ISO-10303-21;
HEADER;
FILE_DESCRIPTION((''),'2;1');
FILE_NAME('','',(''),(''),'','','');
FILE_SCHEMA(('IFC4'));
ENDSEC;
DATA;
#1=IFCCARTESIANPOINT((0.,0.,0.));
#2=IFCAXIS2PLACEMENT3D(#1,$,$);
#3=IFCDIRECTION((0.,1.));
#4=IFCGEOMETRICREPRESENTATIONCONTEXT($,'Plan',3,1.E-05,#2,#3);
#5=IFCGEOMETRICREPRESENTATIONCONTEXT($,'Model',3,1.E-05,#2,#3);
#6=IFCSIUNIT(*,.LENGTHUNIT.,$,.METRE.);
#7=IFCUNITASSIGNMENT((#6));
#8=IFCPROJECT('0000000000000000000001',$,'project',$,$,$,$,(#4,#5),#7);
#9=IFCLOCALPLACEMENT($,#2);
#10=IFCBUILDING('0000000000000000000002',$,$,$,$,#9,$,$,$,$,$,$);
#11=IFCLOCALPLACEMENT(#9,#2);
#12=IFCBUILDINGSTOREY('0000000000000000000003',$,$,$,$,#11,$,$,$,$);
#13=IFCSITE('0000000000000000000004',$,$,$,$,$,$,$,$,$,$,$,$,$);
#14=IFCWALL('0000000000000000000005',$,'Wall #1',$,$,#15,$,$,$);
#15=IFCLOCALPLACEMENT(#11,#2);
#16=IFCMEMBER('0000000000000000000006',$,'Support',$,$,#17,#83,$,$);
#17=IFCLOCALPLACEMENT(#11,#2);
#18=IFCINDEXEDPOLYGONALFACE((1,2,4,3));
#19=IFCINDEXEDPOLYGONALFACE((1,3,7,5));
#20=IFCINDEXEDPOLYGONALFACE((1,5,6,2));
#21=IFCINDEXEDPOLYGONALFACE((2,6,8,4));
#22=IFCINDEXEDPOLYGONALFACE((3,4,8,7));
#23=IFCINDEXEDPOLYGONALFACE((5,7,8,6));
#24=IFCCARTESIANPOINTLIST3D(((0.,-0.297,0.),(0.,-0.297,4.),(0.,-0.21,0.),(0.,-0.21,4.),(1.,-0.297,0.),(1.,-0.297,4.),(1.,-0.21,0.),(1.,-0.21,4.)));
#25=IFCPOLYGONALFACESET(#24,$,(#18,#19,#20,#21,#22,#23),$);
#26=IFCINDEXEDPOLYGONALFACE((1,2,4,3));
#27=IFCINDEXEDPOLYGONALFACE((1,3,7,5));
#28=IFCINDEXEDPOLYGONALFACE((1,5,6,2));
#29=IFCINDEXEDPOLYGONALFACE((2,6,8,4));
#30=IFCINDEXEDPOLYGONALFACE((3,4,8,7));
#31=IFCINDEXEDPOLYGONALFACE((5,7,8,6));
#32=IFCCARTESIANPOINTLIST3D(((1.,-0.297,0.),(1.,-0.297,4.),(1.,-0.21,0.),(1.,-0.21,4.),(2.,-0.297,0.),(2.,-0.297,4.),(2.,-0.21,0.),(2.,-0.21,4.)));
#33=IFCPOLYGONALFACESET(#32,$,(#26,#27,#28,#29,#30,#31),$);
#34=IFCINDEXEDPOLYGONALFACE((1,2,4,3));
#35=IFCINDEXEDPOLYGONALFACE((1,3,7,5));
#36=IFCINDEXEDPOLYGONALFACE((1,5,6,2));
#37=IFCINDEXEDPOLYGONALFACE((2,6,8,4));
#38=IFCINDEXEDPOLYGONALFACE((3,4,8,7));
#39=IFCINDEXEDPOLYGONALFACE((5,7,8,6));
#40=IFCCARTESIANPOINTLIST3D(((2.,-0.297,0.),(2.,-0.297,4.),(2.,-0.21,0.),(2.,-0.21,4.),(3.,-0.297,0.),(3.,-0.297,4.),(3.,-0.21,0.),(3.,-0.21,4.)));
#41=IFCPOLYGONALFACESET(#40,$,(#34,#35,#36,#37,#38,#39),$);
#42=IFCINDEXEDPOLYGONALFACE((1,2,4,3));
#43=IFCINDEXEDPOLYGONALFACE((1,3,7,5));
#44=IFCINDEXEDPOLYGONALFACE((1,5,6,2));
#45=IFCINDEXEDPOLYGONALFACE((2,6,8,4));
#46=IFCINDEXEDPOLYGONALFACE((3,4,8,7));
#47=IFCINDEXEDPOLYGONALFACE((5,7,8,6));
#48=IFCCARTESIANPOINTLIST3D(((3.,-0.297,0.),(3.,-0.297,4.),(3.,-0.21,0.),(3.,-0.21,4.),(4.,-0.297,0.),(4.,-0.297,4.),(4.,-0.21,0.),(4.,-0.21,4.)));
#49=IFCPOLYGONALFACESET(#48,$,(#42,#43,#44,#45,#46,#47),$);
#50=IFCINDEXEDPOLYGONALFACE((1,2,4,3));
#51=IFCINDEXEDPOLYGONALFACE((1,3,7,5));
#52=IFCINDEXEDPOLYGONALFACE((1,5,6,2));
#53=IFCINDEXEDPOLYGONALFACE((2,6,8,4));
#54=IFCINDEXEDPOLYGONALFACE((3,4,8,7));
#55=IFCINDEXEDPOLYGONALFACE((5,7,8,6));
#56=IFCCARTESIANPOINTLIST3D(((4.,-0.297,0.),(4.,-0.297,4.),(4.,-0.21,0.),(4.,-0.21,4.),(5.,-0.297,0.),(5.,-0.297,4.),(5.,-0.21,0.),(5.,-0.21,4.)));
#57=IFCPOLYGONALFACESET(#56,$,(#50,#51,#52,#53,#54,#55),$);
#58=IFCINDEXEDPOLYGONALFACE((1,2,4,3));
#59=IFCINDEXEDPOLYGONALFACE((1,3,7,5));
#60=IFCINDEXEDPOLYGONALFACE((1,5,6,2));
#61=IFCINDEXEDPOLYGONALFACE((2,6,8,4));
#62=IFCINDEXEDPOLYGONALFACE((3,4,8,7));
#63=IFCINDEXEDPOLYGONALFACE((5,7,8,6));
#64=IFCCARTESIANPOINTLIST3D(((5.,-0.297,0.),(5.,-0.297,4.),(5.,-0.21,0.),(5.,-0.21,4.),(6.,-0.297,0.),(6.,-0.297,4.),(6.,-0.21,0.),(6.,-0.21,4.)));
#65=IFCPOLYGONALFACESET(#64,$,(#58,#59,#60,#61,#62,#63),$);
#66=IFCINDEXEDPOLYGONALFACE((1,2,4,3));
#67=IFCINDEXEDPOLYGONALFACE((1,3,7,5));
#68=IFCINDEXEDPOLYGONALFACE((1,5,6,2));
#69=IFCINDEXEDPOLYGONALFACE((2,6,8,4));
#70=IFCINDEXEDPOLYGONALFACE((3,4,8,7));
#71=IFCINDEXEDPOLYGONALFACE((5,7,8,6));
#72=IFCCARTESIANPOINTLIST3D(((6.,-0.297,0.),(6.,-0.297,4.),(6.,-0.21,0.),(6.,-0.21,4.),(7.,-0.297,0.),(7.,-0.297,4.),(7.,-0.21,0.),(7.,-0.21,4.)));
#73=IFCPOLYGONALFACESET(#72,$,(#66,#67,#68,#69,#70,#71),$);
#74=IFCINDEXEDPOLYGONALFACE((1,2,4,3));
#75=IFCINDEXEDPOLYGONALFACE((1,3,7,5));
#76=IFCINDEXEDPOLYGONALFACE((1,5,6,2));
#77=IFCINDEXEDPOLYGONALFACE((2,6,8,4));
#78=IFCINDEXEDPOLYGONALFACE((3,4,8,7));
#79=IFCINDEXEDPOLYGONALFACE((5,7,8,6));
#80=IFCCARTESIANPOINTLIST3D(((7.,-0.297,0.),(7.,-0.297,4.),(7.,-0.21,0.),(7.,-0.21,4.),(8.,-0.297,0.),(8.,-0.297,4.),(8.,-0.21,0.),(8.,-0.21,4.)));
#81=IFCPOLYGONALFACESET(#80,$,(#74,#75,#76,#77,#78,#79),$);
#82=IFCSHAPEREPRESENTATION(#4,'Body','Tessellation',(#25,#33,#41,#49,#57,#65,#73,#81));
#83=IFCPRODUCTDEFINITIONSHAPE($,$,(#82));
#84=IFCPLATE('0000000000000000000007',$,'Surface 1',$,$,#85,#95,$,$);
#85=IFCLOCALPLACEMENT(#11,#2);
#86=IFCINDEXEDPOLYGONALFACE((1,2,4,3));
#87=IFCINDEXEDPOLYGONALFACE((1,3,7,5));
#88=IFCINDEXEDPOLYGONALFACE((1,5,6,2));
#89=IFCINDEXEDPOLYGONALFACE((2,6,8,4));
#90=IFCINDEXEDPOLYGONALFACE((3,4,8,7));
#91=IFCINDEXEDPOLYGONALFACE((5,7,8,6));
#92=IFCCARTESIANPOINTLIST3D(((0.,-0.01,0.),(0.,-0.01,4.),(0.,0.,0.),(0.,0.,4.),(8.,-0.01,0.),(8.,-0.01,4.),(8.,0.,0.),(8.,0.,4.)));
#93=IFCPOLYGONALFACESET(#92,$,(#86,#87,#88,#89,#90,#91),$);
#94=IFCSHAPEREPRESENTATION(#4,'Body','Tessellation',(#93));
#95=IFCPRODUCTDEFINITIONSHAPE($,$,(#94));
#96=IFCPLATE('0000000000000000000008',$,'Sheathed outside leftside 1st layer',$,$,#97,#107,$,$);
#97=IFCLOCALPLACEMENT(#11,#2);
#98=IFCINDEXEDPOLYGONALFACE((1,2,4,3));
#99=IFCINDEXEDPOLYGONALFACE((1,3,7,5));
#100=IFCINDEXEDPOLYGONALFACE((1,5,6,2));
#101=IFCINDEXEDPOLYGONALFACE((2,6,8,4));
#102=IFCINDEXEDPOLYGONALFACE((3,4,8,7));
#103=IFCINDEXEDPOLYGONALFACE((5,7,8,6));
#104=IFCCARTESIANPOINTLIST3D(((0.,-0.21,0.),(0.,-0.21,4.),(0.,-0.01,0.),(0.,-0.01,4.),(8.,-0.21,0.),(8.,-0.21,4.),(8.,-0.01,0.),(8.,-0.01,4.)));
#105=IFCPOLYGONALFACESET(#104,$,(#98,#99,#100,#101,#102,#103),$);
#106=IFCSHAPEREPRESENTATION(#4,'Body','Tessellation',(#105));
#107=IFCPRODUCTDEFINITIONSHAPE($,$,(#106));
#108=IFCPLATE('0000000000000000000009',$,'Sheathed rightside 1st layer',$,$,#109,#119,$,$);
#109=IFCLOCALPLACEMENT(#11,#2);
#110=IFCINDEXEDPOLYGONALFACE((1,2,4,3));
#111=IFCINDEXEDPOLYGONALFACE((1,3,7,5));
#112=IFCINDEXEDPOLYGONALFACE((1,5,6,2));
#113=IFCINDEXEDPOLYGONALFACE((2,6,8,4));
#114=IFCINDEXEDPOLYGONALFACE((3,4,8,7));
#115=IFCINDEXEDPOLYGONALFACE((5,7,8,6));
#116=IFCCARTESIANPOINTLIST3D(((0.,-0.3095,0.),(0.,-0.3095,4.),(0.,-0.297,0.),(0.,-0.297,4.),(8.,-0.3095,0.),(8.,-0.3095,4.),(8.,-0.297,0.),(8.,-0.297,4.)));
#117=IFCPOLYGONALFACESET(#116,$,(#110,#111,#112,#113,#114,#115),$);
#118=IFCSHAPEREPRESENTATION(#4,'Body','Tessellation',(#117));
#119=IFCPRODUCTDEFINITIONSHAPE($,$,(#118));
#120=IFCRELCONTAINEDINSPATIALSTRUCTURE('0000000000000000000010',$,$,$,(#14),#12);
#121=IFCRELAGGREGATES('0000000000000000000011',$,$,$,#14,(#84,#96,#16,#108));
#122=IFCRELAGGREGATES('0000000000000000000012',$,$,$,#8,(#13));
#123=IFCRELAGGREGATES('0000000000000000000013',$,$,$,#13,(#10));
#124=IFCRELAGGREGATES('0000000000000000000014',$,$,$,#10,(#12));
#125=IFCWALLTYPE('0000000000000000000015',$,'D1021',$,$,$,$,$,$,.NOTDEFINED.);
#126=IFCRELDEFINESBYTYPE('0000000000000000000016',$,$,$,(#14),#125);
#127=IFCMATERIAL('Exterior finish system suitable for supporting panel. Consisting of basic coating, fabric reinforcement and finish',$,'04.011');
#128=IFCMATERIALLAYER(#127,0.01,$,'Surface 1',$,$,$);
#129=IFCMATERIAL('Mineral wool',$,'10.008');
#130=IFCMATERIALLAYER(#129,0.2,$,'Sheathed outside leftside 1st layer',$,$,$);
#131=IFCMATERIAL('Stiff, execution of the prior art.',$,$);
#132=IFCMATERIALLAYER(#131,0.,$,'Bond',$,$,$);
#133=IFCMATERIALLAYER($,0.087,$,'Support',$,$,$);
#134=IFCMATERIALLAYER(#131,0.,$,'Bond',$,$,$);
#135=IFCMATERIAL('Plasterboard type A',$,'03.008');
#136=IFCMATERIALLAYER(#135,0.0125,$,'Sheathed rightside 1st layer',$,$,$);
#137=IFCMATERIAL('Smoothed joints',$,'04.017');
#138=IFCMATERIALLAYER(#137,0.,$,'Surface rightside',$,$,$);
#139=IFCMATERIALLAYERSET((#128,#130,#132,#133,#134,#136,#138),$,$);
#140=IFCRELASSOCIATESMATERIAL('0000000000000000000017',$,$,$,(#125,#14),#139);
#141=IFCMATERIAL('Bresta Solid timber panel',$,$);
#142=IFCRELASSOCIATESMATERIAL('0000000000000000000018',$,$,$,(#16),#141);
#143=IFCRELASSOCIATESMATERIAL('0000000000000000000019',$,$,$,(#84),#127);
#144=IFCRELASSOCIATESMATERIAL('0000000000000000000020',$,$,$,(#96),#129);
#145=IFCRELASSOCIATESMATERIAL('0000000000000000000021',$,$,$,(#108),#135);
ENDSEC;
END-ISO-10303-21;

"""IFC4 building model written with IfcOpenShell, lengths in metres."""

from ifc_helpers import new_model, si_unit, direction, frame, frame_2d, origin, origin_with_axes, place, context, project, spatial, rectangle, extrude, material, layer, layer_set, type_object, element, aggregate, save


model = new_model("IFC4")

# Units and contexts
plan_context = context("Plan", 3, precision=1e-05, world=origin(), true_north=direction((0.0, 1.0)))
model_context = context("Model", 3, precision=1e-05, world=origin(), true_north=direction((0.0, 1.0)))
ifc_project = project(units=[si_unit("LENGTHUNIT", "METRE")], contexts=[plan_context, model_context])

# Site, building, storey
site = spatial("IfcSite", under=ifc_project)
building_placement = place(None, origin())
building = spatial("IfcBuilding", under=site, at=building_placement)
storey_placement = place(building_placement, origin())
storey = spatial("IfcBuildingStorey", under=building, at=storey_placement)

# Wall, member, plates
ifc_material_1 = material(Name="Exterior finish system suitable for supporting panel. Consisting of basic coating, fabric reinforcement and finish", Category="04.011")
ifc_layer_1 = layer(ifc_material_1, 0.01, Name="Surface 1")
ifc_material_2 = material(Name="Mineral wool", Category="10.008")
ifc_layer_2 = layer(ifc_material_2, 0.2, Name="Sheathed outside leftside 1st layer")
ifc_material_3 = material(Name="Stiff, execution of the prior art.")
ifc_layer_3 = layer(ifc_material_3, 0.0, Name="Bond")
ifc_layer_4 = layer(None, 0.087, Name="Support")
ifc_layer_5 = layer(ifc_material_3, 0.0, Name="Bond")
ifc_material_4 = material(Name="Plasterboard type A", Category="03.008")
ifc_layer_6 = layer(ifc_material_4, 0.0125, Name="Sheathed rightside 1st layer")
ifc_material_5 = material(Name="Smoothed joints", Category="04.017")
ifc_layer_7 = layer(ifc_material_5, 0.0, Name="Surface rightside")
ifc_layer_set = layer_set([ifc_layer_1, ifc_layer_2, ifc_layer_3, ifc_layer_4, ifc_layer_5, ifc_layer_6, ifc_layer_7])
wall_type = type_object("IfcWallType", Name="D1021", PredefinedType="NOTDEFINED", material=ifc_layer_set)
wall_placement = place(None, frame((0.0, 0.0, 0.0), z_axis=(0.0, -1.0, 0.0), x_axis=(1.0, 0.0, 0.0)))
wall = element("IfcWall", 1, at=wall_placement, inside=storey, type_object=wall_type, material=ifc_layer_set, Name="Wall #1")
ifc_material_6 = material(Name="Bresta Solid timber panel")
member_placement = place(wall_placement, origin())
member = element("IfcMember", 2, at=member_placement, material=ifc_material_6, Name="Support", context=plan_context, shape_type="SweptSolid", body=[
    extrude(rectangle(XDim=1.0, YDim=0.087, at=frame_2d((0.5, 0.0435), x_axis=(1.0, 0.0))), frame((0.0, 4.0, 0.21), z_axis=(0.0, -1.0, 0.0), x_axis=(1.0, 0.0, 0.0)), (0.0, 0.0, 1.0), 4.0),
    extrude(rectangle(XDim=1.0, YDim=0.087, at=frame_2d((0.5, 0.0435), x_axis=(1.0, 0.0))), frame((1.0, 4.0, 0.21), z_axis=(0.0, -1.0, 0.0), x_axis=(1.0, 0.0, 0.0)), (0.0, 0.0, 1.0), 4.0),
    extrude(rectangle(XDim=1.0, YDim=0.087, at=frame_2d((0.5, 0.0435), x_axis=(1.0, 0.0))), frame((2.0, 4.0, 0.21), z_axis=(0.0, -1.0, 0.0), x_axis=(1.0, 0.0, 0.0)), (0.0, 0.0, 1.0), 4.0),
    extrude(rectangle(XDim=1.0, YDim=0.087, at=frame_2d((0.5, 0.0435), x_axis=(1.0, 0.0))), frame((3.0, 4.0, 0.21), z_axis=(0.0, -1.0, 0.0), x_axis=(1.0, 0.0, 0.0)), (0.0, 0.0, 1.0), 4.0),
    extrude(rectangle(XDim=1.0, YDim=0.087, at=frame_2d((0.5, 0.0435), x_axis=(1.0, 0.0))), frame((4.0, 4.0, 0.21), z_axis=(0.0, -1.0, 0.0), x_axis=(1.0, 0.0, 0.0)), (0.0, 0.0, 1.0), 4.0),
    extrude(rectangle(XDim=1.0, YDim=0.087, at=frame_2d((0.5, 0.0435), x_axis=(1.0, 0.0))), frame((5.0, 4.0, 0.21), z_axis=(0.0, -1.0, 0.0), x_axis=(1.0, 0.0, 0.0)), (0.0, 0.0, 1.0), 4.0),
    extrude(rectangle(XDim=1.0, YDim=0.087, at=frame_2d((0.5, 0.0435), x_axis=(1.0, 0.0))), frame((6.0, 4.0, 0.21), z_axis=(0.0, -1.0, 0.0), x_axis=(1.0, 0.0, 0.0)), (0.0, 0.0, 1.0), 4.0),
    extrude(rectangle(XDim=1.0, YDim=0.087, at=frame_2d((0.5, 0.0435), x_axis=(1.0, 0.0))), frame((7.0, 4.0, 0.21), z_axis=(0.0, -1.0, 0.0), x_axis=(1.0, 0.0, 0.0)), (0.0, 0.0, 1.0), 4.0),
])
plate_1_placement = place(wall_placement, origin())
plate_1 = element("IfcPlate", 3, at=plate_1_placement, material=ifc_material_1, Name="Surface 1", context=plan_context, shape_type="SweptSolid", body=[
    extrude(rectangle(XDim=8.0, YDim=4.0, at=frame_2d((4.0, 2.0), x_axis=(1.0, 0.0))), origin_with_axes(), (0.0, 0.0, 1.0), 0.01),
])
plate_2_placement = place(wall_placement, origin())
plate_2 = element("IfcPlate", 4, at=plate_2_placement, material=ifc_material_2, Name="Sheathed outside leftside 1st layer", context=plan_context, shape_type="SweptSolid", body=[
    extrude(rectangle(XDim=8.0, YDim=4.0, at=frame_2d((4.0, 2.0), x_axis=(1.0, 0.0))), frame((0.0, 0.0, 0.01), z_axis=(0.0, 0.0, 1.0), x_axis=(1.0, 0.0, 0.0)), (0.0, 0.0, 1.0), 0.2),
])
plate_3_placement = place(wall_placement, origin())
plate_3 = element("IfcPlate", 5, at=plate_3_placement, material=ifc_material_4, Name="Sheathed rightside 1st layer", context=plan_context, shape_type="SweptSolid", body=[
    extrude(rectangle(XDim=8.0, YDim=4.0, at=frame_2d((4.0, 2.0), x_axis=(1.0, 0.0))), frame((0.0, 0.0, 0.297), z_axis=(0.0, 0.0, 1.0), x_axis=(1.0, 0.0, 0.0)), (0.0, 0.0, 1.0), 0.0125),
])
aggregate(wall, [plate_1, plate_2, member, plate_3])

save(model, "model.ifc")
